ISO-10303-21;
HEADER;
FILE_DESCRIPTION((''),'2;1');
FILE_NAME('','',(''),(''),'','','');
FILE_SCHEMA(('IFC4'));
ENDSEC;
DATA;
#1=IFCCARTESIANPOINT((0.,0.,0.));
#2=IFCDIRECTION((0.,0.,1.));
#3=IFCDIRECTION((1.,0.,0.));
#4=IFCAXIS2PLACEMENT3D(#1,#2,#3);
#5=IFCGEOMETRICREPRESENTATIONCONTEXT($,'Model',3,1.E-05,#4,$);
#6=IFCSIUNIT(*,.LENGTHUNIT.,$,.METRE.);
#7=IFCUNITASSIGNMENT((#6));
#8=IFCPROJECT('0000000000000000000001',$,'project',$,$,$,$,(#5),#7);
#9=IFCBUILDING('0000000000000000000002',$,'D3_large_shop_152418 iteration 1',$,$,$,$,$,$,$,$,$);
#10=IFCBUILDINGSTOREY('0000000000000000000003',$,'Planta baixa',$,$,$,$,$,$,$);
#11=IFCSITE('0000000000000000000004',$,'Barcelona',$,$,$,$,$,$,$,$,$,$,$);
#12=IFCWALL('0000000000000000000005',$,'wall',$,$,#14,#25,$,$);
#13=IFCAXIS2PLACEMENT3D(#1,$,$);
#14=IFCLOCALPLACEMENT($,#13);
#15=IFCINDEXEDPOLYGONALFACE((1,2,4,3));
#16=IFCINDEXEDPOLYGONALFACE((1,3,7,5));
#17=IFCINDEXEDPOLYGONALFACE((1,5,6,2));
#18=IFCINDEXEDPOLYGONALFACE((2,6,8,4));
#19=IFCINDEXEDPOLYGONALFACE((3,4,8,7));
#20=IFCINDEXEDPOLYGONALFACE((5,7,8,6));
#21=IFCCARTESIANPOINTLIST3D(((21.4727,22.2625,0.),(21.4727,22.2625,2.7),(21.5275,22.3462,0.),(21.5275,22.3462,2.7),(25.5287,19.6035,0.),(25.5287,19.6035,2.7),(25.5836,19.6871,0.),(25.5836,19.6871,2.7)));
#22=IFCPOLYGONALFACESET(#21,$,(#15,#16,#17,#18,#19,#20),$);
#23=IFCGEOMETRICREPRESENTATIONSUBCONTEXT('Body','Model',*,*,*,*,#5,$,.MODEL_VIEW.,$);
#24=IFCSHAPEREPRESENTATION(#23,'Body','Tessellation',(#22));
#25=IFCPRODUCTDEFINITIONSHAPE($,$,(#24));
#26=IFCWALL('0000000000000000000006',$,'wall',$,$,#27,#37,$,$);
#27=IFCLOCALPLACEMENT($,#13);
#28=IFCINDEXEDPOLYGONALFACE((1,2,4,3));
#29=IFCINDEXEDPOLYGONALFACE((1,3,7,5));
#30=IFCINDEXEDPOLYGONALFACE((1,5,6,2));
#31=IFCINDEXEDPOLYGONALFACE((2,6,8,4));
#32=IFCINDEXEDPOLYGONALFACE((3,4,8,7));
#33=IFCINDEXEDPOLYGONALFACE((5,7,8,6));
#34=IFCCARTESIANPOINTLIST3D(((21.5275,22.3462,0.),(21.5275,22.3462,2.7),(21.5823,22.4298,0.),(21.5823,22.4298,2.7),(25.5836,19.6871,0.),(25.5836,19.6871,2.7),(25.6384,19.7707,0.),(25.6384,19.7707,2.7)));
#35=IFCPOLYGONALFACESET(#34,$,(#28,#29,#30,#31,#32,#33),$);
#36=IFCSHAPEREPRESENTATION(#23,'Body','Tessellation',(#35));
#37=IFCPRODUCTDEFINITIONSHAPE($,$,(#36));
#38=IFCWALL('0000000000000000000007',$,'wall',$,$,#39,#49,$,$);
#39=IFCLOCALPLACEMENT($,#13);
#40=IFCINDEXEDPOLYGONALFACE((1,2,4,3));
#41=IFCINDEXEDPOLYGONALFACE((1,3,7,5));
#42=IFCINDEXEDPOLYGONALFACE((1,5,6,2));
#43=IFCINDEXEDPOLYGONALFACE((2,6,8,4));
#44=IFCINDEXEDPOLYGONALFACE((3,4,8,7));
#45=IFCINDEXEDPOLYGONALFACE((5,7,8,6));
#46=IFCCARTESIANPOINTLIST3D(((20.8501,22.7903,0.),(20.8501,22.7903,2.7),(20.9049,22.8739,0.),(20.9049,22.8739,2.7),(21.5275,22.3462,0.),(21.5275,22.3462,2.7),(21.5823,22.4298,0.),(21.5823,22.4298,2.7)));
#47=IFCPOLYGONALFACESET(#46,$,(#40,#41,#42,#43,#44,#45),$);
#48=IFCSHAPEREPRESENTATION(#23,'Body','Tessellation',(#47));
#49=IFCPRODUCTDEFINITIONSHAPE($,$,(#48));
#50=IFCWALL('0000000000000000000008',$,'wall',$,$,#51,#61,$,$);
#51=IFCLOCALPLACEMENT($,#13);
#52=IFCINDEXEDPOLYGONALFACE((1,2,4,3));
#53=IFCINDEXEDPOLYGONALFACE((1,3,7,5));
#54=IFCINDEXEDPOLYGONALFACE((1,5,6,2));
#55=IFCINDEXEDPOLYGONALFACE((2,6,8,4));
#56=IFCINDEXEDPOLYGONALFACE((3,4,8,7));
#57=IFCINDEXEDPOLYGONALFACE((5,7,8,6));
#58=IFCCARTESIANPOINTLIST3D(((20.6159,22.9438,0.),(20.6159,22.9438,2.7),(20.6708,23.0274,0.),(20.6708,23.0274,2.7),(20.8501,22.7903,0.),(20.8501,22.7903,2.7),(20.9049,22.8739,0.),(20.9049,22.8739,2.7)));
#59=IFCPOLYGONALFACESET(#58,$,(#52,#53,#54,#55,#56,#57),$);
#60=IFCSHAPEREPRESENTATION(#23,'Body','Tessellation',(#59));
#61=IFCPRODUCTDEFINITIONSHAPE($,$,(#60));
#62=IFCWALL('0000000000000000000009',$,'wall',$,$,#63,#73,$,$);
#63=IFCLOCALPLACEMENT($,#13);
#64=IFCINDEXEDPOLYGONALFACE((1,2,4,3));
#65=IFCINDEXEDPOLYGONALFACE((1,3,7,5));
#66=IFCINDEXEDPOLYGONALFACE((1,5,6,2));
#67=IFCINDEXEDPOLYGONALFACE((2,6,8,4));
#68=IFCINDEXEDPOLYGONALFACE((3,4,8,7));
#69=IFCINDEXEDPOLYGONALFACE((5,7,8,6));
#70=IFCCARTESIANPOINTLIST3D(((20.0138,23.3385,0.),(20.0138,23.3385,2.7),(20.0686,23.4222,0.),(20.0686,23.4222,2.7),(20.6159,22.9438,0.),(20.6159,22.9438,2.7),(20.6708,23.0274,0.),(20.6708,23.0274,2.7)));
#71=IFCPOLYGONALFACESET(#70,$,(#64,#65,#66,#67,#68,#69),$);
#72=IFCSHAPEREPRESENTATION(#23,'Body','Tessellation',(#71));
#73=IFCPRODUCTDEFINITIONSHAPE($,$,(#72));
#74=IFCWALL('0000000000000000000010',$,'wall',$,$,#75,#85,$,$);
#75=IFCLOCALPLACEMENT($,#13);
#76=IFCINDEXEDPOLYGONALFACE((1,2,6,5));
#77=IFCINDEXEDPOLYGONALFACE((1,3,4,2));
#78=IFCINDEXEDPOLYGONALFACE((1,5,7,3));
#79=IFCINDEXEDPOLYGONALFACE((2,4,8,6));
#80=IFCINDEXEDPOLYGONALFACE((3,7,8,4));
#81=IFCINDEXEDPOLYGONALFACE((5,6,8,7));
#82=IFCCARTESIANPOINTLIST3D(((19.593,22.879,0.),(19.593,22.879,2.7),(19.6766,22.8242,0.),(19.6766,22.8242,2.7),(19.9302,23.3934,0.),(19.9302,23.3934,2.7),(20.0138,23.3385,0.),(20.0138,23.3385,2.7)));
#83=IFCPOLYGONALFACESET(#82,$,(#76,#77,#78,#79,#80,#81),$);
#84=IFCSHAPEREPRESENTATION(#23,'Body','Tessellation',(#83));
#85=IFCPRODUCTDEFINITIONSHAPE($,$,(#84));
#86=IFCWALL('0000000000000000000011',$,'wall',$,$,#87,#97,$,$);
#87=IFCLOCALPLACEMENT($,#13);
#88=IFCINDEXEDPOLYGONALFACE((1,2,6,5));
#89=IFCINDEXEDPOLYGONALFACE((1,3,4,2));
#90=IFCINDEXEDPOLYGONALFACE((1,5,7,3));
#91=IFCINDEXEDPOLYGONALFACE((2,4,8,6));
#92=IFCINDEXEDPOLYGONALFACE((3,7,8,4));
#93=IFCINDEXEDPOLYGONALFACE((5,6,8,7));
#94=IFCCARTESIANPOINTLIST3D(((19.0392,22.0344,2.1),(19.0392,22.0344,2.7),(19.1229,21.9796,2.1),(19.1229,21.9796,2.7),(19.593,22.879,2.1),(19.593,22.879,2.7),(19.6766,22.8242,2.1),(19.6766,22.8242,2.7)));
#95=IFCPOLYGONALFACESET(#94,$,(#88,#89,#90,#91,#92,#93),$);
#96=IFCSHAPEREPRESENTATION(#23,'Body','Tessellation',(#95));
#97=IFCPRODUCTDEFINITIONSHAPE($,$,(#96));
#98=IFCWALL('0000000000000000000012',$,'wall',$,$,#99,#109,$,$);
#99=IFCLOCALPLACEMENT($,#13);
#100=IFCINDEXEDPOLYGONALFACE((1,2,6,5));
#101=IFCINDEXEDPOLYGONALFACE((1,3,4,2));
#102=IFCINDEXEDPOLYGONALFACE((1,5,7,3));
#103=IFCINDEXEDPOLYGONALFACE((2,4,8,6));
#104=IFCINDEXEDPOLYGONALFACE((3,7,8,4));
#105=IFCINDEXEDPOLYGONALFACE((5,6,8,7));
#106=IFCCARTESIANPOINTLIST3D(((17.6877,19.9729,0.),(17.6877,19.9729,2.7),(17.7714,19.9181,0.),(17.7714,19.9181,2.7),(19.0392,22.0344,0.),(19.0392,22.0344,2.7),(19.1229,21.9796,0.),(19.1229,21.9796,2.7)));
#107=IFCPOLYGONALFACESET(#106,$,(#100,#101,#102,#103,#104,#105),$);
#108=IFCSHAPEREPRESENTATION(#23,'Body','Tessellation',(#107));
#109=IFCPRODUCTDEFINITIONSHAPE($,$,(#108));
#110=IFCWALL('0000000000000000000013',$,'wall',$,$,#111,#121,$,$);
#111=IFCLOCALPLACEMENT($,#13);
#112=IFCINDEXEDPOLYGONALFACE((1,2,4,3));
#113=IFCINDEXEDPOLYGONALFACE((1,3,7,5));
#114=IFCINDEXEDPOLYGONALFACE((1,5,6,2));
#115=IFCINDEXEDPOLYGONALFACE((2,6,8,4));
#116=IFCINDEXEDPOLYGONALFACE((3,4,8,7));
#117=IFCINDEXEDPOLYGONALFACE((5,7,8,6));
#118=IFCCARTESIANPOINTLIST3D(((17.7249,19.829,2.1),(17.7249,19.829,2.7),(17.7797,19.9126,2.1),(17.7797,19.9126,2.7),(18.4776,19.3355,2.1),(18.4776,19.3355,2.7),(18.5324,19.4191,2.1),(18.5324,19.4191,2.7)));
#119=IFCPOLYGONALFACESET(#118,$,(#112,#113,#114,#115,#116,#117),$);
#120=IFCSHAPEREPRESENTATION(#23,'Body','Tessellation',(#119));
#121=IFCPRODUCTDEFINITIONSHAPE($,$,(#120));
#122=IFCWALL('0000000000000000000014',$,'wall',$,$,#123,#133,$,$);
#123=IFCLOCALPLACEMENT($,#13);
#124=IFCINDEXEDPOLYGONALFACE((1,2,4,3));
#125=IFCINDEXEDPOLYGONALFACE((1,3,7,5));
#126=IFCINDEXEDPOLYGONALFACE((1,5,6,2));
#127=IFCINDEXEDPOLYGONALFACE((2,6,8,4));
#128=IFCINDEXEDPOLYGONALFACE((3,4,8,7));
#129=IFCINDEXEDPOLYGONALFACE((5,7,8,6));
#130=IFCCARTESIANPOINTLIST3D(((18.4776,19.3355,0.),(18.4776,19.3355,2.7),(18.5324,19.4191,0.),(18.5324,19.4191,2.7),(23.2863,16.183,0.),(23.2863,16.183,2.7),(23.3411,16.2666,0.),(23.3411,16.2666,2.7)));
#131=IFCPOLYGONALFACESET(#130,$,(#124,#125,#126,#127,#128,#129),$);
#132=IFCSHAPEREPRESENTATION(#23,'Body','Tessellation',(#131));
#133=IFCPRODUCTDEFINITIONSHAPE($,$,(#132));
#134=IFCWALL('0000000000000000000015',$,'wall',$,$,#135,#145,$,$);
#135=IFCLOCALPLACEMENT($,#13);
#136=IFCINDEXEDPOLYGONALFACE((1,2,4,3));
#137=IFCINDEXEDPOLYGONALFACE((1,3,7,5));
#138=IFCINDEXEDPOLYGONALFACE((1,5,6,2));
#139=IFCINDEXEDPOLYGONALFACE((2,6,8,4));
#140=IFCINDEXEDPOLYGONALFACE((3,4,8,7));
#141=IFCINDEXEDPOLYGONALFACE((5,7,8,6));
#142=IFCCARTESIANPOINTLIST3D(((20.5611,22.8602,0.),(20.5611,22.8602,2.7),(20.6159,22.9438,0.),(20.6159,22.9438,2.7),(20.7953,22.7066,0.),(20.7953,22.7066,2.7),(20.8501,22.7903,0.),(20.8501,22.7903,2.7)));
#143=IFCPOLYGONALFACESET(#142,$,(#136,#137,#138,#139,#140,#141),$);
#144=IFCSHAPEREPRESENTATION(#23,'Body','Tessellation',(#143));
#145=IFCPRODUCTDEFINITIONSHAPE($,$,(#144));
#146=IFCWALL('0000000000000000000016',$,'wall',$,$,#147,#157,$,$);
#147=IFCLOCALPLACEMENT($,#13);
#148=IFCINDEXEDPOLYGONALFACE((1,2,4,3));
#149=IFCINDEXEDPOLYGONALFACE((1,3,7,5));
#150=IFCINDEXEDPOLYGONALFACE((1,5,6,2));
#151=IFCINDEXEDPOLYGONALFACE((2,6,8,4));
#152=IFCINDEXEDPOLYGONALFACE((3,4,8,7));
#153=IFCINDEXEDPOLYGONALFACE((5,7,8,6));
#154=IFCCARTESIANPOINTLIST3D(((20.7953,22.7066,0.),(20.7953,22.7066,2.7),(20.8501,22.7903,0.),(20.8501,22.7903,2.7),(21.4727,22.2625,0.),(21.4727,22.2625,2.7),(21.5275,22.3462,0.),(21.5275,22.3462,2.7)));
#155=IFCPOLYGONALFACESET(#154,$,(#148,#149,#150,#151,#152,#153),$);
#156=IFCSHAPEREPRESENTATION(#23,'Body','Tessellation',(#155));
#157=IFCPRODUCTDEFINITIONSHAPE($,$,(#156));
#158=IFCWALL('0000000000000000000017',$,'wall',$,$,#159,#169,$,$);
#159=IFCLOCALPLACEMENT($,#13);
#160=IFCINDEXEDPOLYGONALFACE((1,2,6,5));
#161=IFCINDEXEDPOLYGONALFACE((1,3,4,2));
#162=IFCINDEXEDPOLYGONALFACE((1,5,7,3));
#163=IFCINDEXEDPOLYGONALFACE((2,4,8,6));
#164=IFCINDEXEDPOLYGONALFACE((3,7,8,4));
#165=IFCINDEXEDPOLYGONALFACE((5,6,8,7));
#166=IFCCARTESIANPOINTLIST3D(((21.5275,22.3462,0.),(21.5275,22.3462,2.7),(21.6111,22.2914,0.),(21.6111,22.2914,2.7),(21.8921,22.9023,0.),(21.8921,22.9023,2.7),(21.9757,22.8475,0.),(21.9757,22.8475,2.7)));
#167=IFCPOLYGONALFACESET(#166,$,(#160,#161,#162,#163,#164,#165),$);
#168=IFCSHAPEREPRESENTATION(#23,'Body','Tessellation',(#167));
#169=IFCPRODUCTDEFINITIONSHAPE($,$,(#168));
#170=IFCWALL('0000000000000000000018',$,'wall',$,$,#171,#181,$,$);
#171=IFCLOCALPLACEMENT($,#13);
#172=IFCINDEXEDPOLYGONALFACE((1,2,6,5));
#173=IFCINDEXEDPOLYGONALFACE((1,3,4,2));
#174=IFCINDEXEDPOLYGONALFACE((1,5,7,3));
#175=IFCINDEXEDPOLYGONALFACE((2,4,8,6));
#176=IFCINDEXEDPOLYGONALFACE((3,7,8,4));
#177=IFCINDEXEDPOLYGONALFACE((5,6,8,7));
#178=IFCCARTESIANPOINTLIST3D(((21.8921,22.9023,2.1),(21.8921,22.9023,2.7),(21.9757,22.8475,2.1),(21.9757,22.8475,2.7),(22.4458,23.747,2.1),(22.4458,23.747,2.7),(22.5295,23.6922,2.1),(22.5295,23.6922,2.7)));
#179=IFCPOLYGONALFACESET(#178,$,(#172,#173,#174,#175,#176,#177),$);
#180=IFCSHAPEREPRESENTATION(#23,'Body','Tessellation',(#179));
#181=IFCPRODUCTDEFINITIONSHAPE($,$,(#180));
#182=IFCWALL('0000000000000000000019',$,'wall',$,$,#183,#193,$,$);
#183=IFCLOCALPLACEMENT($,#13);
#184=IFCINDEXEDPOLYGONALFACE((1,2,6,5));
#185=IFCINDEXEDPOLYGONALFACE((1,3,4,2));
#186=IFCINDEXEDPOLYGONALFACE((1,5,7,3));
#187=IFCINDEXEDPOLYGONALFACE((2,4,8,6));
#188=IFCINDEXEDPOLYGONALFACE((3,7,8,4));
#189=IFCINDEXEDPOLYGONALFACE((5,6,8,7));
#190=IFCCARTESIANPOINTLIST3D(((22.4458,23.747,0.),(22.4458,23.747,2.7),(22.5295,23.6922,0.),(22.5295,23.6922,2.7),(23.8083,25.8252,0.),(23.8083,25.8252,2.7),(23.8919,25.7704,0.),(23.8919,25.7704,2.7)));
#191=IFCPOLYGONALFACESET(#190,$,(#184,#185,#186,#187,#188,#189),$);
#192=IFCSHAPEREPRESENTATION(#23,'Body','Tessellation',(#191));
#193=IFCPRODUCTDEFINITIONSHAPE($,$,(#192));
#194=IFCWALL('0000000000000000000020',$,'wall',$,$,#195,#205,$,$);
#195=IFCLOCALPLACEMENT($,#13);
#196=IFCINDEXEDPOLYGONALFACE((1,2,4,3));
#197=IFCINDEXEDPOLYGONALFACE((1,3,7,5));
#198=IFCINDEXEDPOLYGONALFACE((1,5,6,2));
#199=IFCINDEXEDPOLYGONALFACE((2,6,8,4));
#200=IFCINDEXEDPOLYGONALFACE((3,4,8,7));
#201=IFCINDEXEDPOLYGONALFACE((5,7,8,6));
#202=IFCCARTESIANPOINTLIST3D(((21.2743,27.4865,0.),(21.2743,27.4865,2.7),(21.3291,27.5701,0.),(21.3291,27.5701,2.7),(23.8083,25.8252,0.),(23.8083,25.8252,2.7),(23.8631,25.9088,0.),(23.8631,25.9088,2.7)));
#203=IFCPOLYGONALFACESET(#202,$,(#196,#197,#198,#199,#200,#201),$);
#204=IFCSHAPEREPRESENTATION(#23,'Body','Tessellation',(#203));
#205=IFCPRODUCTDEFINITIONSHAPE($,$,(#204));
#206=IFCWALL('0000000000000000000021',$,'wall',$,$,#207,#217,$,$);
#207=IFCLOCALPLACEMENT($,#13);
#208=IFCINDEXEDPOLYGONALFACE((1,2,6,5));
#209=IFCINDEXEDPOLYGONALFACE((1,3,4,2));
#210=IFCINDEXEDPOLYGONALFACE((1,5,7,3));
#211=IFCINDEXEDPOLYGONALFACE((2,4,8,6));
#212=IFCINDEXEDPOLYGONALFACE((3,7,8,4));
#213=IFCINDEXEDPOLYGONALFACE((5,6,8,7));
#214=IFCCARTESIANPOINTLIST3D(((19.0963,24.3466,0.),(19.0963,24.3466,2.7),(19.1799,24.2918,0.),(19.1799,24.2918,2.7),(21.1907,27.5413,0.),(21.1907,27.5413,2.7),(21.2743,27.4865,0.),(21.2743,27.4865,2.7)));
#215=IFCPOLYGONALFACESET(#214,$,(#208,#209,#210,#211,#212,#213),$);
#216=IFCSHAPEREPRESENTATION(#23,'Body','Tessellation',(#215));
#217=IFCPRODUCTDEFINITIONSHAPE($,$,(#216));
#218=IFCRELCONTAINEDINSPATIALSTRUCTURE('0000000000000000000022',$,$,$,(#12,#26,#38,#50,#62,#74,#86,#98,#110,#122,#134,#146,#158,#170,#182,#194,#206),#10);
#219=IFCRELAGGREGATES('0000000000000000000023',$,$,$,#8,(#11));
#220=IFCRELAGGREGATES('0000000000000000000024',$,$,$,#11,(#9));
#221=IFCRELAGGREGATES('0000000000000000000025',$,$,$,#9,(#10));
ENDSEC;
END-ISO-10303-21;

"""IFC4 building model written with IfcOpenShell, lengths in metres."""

from ifc_helpers import new_model, si_unit, frame, origin, origin_with_axes, place, context, subcontext, project, spatial, polyline, outline, extrude, element, save


model = new_model("IFC4")

# Units and contexts
model_context = context("Model", 3, precision=1e-05, world=origin_with_axes())
body_context = subcontext(model_context, "Body", "Model", "MODEL_VIEW")
ifc_project = project(units=[si_unit("LENGTHUNIT", "METRE")], contexts=[model_context])

# Site, building, storey
site = spatial("IfcSite", under=ifc_project, Name="Barcelona")
building = spatial("IfcBuilding", under=site, Name="D3_large_shop_152418 iteration 1")
storey = spatial("IfcBuildingStorey", under=building, Name="Planta baixa")

# Walls
wall_1_placement = place(None, origin_with_axes())
element("IfcWall", 1, at=wall_1_placement, inside=storey, Name="wall", context=body_context, shape_type="SweptSolid", body=[
    extrude(outline(polyline([(21.5275, 22.3462), (25.5836, 19.6871), (25.5287, 19.6035), (21.4727, 22.2625), (21.5275, 22.3462)])), origin(), (0.0, 0.0, 1.0), 2.7),
])
wall_2_placement = place(None, origin_with_axes())
element("IfcWall", 2, at=wall_2_placement, inside=storey, Name="wall", context=body_context, shape_type="SweptSolid", body=[
    extrude(outline(polyline([(25.5836, 19.6871), (21.5275, 22.3462), (21.5823, 22.4298), (25.6384, 19.7707), (25.5836, 19.6871)])), origin(), (0.0, 0.0, 1.0), 2.7),
])
wall_3_placement = place(None, origin_with_axes())
element("IfcWall", 3, at=wall_3_placement, inside=storey, Name="wall", context=body_context, shape_type="SweptSolid", body=[
    extrude(outline(polyline([(21.5275, 22.3462), (20.8501, 22.7903), (20.9049, 22.8739), (21.5823, 22.4298), (21.5275, 22.3462)])), origin(), (0.0, 0.0, 1.0), 2.7),
])
wall_4_placement = place(None, origin_with_axes())
element("IfcWall", 4, at=wall_4_placement, inside=storey, Name="wall", context=body_context, shape_type="SweptSolid", body=[
    extrude(outline(polyline([(20.8501, 22.7903), (20.6159, 22.9438), (20.6708, 23.0274), (20.9049, 22.8739), (20.8501, 22.7903)])), origin(), (0.0, 0.0, 1.0), 2.7),
])
wall_5_placement = place(None, origin_with_axes())
element("IfcWall", 5, at=wall_5_placement, inside=storey, Name="wall", context=body_context, shape_type="SweptSolid", body=[
    extrude(outline(polyline([(20.6159, 22.9438), (20.0138, 23.3385), (20.0686, 23.4222), (20.6708, 23.0274), (20.6159, 22.9438)])), origin(), (0.0, 0.0, 1.0), 2.7),
])
wall_6_placement = place(None, origin_with_axes())
element("IfcWall", 6, at=wall_6_placement, inside=storey, Name="wall", context=body_context, shape_type="SweptSolid", body=[
    extrude(outline(polyline([(20.0138, 23.3385), (19.6766, 22.8242), (19.593, 22.879), (19.9302, 23.3934), (20.0138, 23.3385)])), origin(), (0.0, 0.0, 1.0), 2.7),
])
wall_7_placement = place(None, origin_with_axes())
element("IfcWall", 7, at=wall_7_placement, inside=storey, Name="wall", context=body_context, shape_type="SweptSolid", body=[
    extrude(outline(polyline([(19.6766, 22.8242), (19.1229, 21.9796), (19.0392, 22.0344), (19.593, 22.879), (19.6766, 22.8242)])), frame((0.0, 0.0, 2.1)), (0.0, 0.0, 1.0), 0.6),
])
wall_8_placement = place(None, origin_with_axes())
element("IfcWall", 8, at=wall_8_placement, inside=storey, Name="wall", context=body_context, shape_type="SweptSolid", body=[
    extrude(outline(polyline([(19.1229, 21.9796), (17.7714, 19.9181), (17.6877, 19.9729), (19.0392, 22.0344), (19.1229, 21.9796)])), origin(), (0.0, 0.0, 1.0), 2.7),
])
wall_9_placement = place(None, origin_with_axes())
element("IfcWall", 9, at=wall_9_placement, inside=storey, Name="wall", context=body_context, shape_type="SweptSolid", body=[
    extrude(outline(polyline([(17.7797, 19.9126), (18.5324, 19.4191), (18.4776, 19.3355), (17.7249, 19.829), (17.7797, 19.9126)])), frame((0.0, 0.0, 2.1)), (0.0, 0.0, 1.0), 0.6),
])
wall_10_placement = place(None, origin_with_axes())
element("IfcWall", 10, at=wall_10_placement, inside=storey, Name="wall", context=body_context, shape_type="SweptSolid", body=[
    extrude(outline(polyline([(18.5324, 19.4191), (23.3411, 16.2666), (23.2863, 16.183), (18.4776, 19.3355), (18.5324, 19.4191)])), origin(), (0.0, 0.0, 1.0), 2.7),
])
wall_11_placement = place(None, origin_with_axes())
element("IfcWall", 11, at=wall_11_placement, inside=storey, Name="wall", context=body_context, shape_type="SweptSolid", body=[
    extrude(outline(polyline([(20.6159, 22.9438), (20.8501, 22.7903), (20.7953, 22.7066), (20.5611, 22.8602), (20.6159, 22.9438)])), origin(), (0.0, 0.0, 1.0), 2.7),
])
wall_12_placement = place(None, origin_with_axes())
element("IfcWall", 12, at=wall_12_placement, inside=storey, Name="wall", context=body_context, shape_type="SweptSolid", body=[
    extrude(outline(polyline([(20.8501, 22.7903), (21.5275, 22.3462), (21.4727, 22.2625), (20.7953, 22.7066), (20.8501, 22.7903)])), origin(), (0.0, 0.0, 1.0), 2.7),
])
wall_13_placement = place(None, origin_with_axes())
element("IfcWall", 13, at=wall_13_placement, inside=storey, Name="wall", context=body_context, shape_type="SweptSolid", body=[
    extrude(outline(polyline([(21.5275, 22.3462), (21.8921, 22.9023), (21.9757, 22.8475), (21.6111, 22.2914), (21.5275, 22.3462)])), origin(), (0.0, 0.0, 1.0), 2.7),
])
wall_14_placement = place(None, origin_with_axes())
element("IfcWall", 14, at=wall_14_placement, inside=storey, Name="wall", context=body_context, shape_type="SweptSolid", body=[
    extrude(outline(polyline([(21.8921, 22.9023), (22.4458, 23.747), (22.5295, 23.6922), (21.9757, 22.8475), (21.8921, 22.9023)])), frame((0.0, 0.0, 2.1)), (0.0, 0.0, 1.0), 0.6),
])
wall_15_placement = place(None, origin_with_axes())
element("IfcWall", 15, at=wall_15_placement, inside=storey, Name="wall", context=body_context, shape_type="SweptSolid", body=[
    extrude(outline(polyline([(22.4458, 23.747), (23.8083, 25.8252), (23.8919, 25.7704), (22.5295, 23.6922), (22.4458, 23.747)])), origin(), (0.0, 0.0, 1.0), 2.7),
])
wall_16_placement = place(None, origin_with_axes())
element("IfcWall", 16, at=wall_16_placement, inside=storey, Name="wall", context=body_context, shape_type="SweptSolid", body=[
    extrude(outline(polyline([(23.8083, 25.8252), (21.2743, 27.4865), (21.3291, 27.5701), (23.8631, 25.9088), (23.8083, 25.8252)])), origin(), (0.0, 0.0, 1.0), 2.7),
])
wall_17_placement = place(None, origin_with_axes())
element("IfcWall", 17, at=wall_17_placement, inside=storey, Name="wall", context=body_context, shape_type="SweptSolid", body=[
    extrude(outline(polyline([(21.2743, 27.4865), (19.1799, 24.2918), (19.0963, 24.3466), (21.1907, 27.5413), (21.2743, 27.4865)])), origin(), (0.0, 0.0, 1.0), 2.7),
])

save(model, "model.ifc")
